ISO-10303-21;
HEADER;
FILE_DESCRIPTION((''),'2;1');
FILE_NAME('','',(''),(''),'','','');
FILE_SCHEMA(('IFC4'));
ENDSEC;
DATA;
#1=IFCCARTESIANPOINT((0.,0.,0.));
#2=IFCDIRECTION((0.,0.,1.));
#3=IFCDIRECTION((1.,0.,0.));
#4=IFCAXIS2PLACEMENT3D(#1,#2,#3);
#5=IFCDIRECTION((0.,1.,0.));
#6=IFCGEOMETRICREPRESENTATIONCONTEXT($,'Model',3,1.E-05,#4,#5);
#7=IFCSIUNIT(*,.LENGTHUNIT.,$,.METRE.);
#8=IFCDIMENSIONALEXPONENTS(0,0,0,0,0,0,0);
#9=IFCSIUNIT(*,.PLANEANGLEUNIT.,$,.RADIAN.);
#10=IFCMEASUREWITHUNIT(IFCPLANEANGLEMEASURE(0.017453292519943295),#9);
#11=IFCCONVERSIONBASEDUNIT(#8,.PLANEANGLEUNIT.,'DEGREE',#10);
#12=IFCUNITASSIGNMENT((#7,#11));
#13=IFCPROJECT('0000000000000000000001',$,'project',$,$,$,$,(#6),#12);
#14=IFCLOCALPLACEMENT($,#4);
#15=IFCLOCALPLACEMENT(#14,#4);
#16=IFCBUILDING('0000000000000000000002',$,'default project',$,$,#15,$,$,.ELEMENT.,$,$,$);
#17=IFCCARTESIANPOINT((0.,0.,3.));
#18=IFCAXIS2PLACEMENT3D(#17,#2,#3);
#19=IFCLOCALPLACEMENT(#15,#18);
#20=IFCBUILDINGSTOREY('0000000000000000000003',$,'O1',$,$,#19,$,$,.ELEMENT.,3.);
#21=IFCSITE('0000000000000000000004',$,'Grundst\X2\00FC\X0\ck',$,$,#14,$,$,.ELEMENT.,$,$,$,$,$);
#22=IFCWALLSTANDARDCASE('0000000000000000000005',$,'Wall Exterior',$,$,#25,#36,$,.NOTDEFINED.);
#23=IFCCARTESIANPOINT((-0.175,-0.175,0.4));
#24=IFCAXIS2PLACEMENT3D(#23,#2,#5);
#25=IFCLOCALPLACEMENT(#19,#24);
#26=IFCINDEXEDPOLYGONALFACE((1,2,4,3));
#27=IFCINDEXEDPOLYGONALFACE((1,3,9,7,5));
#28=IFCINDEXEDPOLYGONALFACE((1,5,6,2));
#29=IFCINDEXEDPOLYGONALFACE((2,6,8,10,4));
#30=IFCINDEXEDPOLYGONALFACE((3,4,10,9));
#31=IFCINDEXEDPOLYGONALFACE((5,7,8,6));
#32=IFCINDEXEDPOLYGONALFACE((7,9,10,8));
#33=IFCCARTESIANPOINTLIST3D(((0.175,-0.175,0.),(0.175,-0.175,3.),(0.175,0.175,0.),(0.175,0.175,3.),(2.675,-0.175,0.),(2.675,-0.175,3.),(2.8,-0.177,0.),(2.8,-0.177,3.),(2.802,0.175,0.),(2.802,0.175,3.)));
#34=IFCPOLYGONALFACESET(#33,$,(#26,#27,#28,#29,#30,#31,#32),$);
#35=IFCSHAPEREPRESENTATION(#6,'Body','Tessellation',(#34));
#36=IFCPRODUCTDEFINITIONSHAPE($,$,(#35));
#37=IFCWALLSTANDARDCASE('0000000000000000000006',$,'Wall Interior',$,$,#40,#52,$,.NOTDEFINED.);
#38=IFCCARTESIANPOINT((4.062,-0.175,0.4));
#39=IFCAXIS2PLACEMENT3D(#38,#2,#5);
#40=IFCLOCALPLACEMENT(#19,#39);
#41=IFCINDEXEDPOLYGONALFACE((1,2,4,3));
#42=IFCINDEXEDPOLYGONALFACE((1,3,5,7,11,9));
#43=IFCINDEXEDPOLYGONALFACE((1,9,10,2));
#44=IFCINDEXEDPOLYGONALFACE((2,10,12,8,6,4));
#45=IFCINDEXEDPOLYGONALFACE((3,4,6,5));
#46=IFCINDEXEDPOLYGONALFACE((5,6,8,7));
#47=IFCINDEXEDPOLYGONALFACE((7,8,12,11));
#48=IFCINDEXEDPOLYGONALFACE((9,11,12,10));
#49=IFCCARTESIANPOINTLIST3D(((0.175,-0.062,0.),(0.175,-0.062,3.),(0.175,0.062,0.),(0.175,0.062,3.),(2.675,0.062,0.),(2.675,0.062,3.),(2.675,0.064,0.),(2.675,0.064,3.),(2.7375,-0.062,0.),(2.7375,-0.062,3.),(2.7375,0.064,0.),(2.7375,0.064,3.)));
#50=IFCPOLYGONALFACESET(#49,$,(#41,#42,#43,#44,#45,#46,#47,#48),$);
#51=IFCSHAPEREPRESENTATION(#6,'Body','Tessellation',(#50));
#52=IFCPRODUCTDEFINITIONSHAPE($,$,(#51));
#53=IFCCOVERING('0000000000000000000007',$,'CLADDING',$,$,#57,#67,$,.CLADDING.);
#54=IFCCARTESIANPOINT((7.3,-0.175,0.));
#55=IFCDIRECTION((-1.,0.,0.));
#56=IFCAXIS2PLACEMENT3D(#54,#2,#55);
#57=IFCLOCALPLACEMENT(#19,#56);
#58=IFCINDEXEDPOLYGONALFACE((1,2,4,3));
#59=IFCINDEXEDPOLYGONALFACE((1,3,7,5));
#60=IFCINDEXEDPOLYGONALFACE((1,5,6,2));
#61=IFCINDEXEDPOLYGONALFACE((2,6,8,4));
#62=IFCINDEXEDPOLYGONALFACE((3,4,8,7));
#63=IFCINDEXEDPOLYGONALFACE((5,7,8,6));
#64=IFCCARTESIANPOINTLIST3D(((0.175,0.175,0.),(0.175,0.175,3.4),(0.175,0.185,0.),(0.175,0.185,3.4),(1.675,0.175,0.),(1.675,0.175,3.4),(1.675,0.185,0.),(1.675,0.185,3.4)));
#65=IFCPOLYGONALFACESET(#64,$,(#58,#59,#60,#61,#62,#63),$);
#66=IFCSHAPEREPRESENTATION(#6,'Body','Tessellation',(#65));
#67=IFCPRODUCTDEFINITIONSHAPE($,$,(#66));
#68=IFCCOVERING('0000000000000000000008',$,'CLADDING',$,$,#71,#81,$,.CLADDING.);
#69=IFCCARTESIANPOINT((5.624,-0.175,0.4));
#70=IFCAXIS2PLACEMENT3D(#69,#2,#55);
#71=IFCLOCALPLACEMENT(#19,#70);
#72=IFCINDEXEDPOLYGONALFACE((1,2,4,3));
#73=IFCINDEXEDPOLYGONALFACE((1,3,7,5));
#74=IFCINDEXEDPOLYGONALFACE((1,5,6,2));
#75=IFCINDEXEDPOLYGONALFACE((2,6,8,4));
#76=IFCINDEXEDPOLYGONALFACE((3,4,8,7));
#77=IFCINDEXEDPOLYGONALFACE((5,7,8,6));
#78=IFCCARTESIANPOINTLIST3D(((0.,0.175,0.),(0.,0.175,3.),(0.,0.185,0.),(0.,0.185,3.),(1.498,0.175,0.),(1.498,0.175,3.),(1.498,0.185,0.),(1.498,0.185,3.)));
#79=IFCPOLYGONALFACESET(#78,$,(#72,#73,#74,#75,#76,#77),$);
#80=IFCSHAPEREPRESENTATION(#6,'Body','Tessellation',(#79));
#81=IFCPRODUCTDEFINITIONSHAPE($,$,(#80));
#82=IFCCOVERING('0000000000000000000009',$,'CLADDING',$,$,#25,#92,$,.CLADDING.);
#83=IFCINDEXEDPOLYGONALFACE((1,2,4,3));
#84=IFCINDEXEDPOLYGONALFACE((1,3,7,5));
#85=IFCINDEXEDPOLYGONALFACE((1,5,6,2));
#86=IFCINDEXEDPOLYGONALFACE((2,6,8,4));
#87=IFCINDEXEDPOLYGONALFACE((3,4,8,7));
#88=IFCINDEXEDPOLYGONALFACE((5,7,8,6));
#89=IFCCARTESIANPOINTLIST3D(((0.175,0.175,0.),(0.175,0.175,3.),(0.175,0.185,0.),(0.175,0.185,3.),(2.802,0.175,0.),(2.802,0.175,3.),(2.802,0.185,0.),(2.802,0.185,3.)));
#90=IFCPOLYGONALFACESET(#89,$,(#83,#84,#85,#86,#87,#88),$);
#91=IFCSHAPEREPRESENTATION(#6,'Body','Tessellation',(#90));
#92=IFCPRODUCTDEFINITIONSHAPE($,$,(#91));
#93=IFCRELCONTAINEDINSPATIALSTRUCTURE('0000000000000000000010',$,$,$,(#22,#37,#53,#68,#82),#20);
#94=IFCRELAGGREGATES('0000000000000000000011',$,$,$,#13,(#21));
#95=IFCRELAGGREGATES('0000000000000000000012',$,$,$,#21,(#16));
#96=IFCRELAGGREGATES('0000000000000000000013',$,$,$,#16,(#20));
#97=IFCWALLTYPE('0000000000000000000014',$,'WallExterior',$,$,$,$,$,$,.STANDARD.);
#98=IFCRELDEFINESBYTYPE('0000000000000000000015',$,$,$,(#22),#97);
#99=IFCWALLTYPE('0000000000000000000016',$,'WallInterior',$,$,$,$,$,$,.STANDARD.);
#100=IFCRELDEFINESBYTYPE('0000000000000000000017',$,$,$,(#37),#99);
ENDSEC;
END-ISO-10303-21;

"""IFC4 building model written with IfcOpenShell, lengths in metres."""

from ifc_helpers import new_model, entity, si_unit, converted_unit, direction, frame, origin_with_axes, place, context, project, spatial, polyline, outline, extrude, type_object, element, save


model = new_model("IFC4")

# Units and contexts
model_context = context("Model", 3, precision=1e-05, world=origin_with_axes(), true_north=direction((0.0, 1.0, 0.0)))
ifc_project = project(units=[si_unit("LENGTHUNIT", "METRE"), converted_unit("PLANEANGLEUNIT", "DEGREE", entity("IfcPlaneAngleMeasure", 0.017453292519943295), si_unit("PLANEANGLEUNIT", "RADIAN"), dimensions=[0, 0, 0, 0, 0, 0, 0])], contexts=[model_context])

# Site, building, storey
site_placement = place(None, origin_with_axes())
site = spatial("IfcSite", under=ifc_project, at=site_placement, Name="Grundstück", CompositionType="ELEMENT")
building_placement = place(site_placement, origin_with_axes())
building = spatial("IfcBuilding", under=site, at=building_placement, Name="default project", CompositionType="ELEMENT")
placement_1 = place(building_placement, frame((0.0, 0.0, 3.0), z_axis=(0.0, 0.0, 1.0), x_axis=(1.0, 0.0, 0.0)))
storey = spatial("IfcBuildingStorey", under=building, at=placement_1, Name="O1", CompositionType="ELEMENT", Elevation=3.0)

# Walls
wall_type_1 = type_object("IfcWallType", Name="WallExterior", PredefinedType="STANDARD")
placement_2 = place(placement_1, frame((7.3, -0.175, 0.0), z_axis=(0.0, 0.0, 1.0), x_axis=(-1.0, 0.0, 0.0)))
placement_3 = place(placement_1, frame((5.624, -0.175, 0.4), z_axis=(0.0, 0.0, 1.0), x_axis=(-1.0, 0.0, 0.0)))
placement_4 = place(placement_1, frame((-0.175, -0.175, 0.4), z_axis=(0.0, 0.0, 1.0), x_axis=(0.0, 1.0, 0.0)))
element("IfcWallStandardCase", 1, at=placement_4, inside=storey, type_object=wall_type_1, Name="Wall Exterior", PredefinedType="NOTDEFINED", context=model_context, shape_type="SweptSolid", body=[
    extrude(outline(polyline([(2.802, 0.175), (0.175, 0.175), (0.175, -0.175), (2.675, -0.175), (2.8, -0.177), (2.802, 0.175)])), origin_with_axes(), (0.0, 0.0, 1.0), 3.0),
])
wall_type_2 = type_object("IfcWallType", Name="WallInterior", PredefinedType="STANDARD")
wall_1_placement = place(placement_1, frame((4.062, -0.175, 0.4), z_axis=(0.0, 0.0, 1.0), x_axis=(0.0, 1.0, 0.0)))
element("IfcWallStandardCase", 2, at=wall_1_placement, inside=storey, type_object=wall_type_2, Name="Wall Interior", PredefinedType="NOTDEFINED", context=model_context, shape_type="SweptSolid", body=[
    extrude(outline(polyline([(2.675, 0.062), (0.175, 0.062), (0.175, -0.062), (2.7375, -0.062), (2.7375, 0.064), (2.675, 0.064), (2.675, 0.062)])), origin_with_axes(), (0.0, 0.0, 1.0), 3.0),
])

# Coverings
element("IfcCovering", 3, at=placement_2, inside=storey, Name="CLADDING", PredefinedType="CLADDING", context=model_context, shape_type="SweptSolid", body=[
    extrude(outline(polyline([(1.675, 0.185), (0.175, 0.185), (0.175, 0.175), (1.675, 0.175), (1.675, 0.185)])), origin_with_axes(), (0.0, 0.0, 1.0), 3.4),
])
element("IfcCovering", 4, at=placement_3, inside=storey, Name="CLADDING", PredefinedType="CLADDING", context=model_context, shape_type="SweptSolid", body=[
    extrude(outline(polyline([(1.498, 0.185), (0.0, 0.185), (0.0, 0.175), (1.498, 0.175), (1.498, 0.185)])), origin_with_axes(), (0.0, 0.0, 1.0), 3.0),
])
element("IfcCovering", 5, at=placement_4, inside=storey, Name="CLADDING", PredefinedType="CLADDING", context=model_context, shape_type="SweptSolid", body=[
    extrude(outline(polyline([(2.802, 0.185), (0.175, 0.185), (0.175, 0.175), (2.802, 0.175), (2.802, 0.185)])), origin_with_axes(), (0.0, 0.0, 1.0), 3.0),
])

save(model, "model.ifc")
